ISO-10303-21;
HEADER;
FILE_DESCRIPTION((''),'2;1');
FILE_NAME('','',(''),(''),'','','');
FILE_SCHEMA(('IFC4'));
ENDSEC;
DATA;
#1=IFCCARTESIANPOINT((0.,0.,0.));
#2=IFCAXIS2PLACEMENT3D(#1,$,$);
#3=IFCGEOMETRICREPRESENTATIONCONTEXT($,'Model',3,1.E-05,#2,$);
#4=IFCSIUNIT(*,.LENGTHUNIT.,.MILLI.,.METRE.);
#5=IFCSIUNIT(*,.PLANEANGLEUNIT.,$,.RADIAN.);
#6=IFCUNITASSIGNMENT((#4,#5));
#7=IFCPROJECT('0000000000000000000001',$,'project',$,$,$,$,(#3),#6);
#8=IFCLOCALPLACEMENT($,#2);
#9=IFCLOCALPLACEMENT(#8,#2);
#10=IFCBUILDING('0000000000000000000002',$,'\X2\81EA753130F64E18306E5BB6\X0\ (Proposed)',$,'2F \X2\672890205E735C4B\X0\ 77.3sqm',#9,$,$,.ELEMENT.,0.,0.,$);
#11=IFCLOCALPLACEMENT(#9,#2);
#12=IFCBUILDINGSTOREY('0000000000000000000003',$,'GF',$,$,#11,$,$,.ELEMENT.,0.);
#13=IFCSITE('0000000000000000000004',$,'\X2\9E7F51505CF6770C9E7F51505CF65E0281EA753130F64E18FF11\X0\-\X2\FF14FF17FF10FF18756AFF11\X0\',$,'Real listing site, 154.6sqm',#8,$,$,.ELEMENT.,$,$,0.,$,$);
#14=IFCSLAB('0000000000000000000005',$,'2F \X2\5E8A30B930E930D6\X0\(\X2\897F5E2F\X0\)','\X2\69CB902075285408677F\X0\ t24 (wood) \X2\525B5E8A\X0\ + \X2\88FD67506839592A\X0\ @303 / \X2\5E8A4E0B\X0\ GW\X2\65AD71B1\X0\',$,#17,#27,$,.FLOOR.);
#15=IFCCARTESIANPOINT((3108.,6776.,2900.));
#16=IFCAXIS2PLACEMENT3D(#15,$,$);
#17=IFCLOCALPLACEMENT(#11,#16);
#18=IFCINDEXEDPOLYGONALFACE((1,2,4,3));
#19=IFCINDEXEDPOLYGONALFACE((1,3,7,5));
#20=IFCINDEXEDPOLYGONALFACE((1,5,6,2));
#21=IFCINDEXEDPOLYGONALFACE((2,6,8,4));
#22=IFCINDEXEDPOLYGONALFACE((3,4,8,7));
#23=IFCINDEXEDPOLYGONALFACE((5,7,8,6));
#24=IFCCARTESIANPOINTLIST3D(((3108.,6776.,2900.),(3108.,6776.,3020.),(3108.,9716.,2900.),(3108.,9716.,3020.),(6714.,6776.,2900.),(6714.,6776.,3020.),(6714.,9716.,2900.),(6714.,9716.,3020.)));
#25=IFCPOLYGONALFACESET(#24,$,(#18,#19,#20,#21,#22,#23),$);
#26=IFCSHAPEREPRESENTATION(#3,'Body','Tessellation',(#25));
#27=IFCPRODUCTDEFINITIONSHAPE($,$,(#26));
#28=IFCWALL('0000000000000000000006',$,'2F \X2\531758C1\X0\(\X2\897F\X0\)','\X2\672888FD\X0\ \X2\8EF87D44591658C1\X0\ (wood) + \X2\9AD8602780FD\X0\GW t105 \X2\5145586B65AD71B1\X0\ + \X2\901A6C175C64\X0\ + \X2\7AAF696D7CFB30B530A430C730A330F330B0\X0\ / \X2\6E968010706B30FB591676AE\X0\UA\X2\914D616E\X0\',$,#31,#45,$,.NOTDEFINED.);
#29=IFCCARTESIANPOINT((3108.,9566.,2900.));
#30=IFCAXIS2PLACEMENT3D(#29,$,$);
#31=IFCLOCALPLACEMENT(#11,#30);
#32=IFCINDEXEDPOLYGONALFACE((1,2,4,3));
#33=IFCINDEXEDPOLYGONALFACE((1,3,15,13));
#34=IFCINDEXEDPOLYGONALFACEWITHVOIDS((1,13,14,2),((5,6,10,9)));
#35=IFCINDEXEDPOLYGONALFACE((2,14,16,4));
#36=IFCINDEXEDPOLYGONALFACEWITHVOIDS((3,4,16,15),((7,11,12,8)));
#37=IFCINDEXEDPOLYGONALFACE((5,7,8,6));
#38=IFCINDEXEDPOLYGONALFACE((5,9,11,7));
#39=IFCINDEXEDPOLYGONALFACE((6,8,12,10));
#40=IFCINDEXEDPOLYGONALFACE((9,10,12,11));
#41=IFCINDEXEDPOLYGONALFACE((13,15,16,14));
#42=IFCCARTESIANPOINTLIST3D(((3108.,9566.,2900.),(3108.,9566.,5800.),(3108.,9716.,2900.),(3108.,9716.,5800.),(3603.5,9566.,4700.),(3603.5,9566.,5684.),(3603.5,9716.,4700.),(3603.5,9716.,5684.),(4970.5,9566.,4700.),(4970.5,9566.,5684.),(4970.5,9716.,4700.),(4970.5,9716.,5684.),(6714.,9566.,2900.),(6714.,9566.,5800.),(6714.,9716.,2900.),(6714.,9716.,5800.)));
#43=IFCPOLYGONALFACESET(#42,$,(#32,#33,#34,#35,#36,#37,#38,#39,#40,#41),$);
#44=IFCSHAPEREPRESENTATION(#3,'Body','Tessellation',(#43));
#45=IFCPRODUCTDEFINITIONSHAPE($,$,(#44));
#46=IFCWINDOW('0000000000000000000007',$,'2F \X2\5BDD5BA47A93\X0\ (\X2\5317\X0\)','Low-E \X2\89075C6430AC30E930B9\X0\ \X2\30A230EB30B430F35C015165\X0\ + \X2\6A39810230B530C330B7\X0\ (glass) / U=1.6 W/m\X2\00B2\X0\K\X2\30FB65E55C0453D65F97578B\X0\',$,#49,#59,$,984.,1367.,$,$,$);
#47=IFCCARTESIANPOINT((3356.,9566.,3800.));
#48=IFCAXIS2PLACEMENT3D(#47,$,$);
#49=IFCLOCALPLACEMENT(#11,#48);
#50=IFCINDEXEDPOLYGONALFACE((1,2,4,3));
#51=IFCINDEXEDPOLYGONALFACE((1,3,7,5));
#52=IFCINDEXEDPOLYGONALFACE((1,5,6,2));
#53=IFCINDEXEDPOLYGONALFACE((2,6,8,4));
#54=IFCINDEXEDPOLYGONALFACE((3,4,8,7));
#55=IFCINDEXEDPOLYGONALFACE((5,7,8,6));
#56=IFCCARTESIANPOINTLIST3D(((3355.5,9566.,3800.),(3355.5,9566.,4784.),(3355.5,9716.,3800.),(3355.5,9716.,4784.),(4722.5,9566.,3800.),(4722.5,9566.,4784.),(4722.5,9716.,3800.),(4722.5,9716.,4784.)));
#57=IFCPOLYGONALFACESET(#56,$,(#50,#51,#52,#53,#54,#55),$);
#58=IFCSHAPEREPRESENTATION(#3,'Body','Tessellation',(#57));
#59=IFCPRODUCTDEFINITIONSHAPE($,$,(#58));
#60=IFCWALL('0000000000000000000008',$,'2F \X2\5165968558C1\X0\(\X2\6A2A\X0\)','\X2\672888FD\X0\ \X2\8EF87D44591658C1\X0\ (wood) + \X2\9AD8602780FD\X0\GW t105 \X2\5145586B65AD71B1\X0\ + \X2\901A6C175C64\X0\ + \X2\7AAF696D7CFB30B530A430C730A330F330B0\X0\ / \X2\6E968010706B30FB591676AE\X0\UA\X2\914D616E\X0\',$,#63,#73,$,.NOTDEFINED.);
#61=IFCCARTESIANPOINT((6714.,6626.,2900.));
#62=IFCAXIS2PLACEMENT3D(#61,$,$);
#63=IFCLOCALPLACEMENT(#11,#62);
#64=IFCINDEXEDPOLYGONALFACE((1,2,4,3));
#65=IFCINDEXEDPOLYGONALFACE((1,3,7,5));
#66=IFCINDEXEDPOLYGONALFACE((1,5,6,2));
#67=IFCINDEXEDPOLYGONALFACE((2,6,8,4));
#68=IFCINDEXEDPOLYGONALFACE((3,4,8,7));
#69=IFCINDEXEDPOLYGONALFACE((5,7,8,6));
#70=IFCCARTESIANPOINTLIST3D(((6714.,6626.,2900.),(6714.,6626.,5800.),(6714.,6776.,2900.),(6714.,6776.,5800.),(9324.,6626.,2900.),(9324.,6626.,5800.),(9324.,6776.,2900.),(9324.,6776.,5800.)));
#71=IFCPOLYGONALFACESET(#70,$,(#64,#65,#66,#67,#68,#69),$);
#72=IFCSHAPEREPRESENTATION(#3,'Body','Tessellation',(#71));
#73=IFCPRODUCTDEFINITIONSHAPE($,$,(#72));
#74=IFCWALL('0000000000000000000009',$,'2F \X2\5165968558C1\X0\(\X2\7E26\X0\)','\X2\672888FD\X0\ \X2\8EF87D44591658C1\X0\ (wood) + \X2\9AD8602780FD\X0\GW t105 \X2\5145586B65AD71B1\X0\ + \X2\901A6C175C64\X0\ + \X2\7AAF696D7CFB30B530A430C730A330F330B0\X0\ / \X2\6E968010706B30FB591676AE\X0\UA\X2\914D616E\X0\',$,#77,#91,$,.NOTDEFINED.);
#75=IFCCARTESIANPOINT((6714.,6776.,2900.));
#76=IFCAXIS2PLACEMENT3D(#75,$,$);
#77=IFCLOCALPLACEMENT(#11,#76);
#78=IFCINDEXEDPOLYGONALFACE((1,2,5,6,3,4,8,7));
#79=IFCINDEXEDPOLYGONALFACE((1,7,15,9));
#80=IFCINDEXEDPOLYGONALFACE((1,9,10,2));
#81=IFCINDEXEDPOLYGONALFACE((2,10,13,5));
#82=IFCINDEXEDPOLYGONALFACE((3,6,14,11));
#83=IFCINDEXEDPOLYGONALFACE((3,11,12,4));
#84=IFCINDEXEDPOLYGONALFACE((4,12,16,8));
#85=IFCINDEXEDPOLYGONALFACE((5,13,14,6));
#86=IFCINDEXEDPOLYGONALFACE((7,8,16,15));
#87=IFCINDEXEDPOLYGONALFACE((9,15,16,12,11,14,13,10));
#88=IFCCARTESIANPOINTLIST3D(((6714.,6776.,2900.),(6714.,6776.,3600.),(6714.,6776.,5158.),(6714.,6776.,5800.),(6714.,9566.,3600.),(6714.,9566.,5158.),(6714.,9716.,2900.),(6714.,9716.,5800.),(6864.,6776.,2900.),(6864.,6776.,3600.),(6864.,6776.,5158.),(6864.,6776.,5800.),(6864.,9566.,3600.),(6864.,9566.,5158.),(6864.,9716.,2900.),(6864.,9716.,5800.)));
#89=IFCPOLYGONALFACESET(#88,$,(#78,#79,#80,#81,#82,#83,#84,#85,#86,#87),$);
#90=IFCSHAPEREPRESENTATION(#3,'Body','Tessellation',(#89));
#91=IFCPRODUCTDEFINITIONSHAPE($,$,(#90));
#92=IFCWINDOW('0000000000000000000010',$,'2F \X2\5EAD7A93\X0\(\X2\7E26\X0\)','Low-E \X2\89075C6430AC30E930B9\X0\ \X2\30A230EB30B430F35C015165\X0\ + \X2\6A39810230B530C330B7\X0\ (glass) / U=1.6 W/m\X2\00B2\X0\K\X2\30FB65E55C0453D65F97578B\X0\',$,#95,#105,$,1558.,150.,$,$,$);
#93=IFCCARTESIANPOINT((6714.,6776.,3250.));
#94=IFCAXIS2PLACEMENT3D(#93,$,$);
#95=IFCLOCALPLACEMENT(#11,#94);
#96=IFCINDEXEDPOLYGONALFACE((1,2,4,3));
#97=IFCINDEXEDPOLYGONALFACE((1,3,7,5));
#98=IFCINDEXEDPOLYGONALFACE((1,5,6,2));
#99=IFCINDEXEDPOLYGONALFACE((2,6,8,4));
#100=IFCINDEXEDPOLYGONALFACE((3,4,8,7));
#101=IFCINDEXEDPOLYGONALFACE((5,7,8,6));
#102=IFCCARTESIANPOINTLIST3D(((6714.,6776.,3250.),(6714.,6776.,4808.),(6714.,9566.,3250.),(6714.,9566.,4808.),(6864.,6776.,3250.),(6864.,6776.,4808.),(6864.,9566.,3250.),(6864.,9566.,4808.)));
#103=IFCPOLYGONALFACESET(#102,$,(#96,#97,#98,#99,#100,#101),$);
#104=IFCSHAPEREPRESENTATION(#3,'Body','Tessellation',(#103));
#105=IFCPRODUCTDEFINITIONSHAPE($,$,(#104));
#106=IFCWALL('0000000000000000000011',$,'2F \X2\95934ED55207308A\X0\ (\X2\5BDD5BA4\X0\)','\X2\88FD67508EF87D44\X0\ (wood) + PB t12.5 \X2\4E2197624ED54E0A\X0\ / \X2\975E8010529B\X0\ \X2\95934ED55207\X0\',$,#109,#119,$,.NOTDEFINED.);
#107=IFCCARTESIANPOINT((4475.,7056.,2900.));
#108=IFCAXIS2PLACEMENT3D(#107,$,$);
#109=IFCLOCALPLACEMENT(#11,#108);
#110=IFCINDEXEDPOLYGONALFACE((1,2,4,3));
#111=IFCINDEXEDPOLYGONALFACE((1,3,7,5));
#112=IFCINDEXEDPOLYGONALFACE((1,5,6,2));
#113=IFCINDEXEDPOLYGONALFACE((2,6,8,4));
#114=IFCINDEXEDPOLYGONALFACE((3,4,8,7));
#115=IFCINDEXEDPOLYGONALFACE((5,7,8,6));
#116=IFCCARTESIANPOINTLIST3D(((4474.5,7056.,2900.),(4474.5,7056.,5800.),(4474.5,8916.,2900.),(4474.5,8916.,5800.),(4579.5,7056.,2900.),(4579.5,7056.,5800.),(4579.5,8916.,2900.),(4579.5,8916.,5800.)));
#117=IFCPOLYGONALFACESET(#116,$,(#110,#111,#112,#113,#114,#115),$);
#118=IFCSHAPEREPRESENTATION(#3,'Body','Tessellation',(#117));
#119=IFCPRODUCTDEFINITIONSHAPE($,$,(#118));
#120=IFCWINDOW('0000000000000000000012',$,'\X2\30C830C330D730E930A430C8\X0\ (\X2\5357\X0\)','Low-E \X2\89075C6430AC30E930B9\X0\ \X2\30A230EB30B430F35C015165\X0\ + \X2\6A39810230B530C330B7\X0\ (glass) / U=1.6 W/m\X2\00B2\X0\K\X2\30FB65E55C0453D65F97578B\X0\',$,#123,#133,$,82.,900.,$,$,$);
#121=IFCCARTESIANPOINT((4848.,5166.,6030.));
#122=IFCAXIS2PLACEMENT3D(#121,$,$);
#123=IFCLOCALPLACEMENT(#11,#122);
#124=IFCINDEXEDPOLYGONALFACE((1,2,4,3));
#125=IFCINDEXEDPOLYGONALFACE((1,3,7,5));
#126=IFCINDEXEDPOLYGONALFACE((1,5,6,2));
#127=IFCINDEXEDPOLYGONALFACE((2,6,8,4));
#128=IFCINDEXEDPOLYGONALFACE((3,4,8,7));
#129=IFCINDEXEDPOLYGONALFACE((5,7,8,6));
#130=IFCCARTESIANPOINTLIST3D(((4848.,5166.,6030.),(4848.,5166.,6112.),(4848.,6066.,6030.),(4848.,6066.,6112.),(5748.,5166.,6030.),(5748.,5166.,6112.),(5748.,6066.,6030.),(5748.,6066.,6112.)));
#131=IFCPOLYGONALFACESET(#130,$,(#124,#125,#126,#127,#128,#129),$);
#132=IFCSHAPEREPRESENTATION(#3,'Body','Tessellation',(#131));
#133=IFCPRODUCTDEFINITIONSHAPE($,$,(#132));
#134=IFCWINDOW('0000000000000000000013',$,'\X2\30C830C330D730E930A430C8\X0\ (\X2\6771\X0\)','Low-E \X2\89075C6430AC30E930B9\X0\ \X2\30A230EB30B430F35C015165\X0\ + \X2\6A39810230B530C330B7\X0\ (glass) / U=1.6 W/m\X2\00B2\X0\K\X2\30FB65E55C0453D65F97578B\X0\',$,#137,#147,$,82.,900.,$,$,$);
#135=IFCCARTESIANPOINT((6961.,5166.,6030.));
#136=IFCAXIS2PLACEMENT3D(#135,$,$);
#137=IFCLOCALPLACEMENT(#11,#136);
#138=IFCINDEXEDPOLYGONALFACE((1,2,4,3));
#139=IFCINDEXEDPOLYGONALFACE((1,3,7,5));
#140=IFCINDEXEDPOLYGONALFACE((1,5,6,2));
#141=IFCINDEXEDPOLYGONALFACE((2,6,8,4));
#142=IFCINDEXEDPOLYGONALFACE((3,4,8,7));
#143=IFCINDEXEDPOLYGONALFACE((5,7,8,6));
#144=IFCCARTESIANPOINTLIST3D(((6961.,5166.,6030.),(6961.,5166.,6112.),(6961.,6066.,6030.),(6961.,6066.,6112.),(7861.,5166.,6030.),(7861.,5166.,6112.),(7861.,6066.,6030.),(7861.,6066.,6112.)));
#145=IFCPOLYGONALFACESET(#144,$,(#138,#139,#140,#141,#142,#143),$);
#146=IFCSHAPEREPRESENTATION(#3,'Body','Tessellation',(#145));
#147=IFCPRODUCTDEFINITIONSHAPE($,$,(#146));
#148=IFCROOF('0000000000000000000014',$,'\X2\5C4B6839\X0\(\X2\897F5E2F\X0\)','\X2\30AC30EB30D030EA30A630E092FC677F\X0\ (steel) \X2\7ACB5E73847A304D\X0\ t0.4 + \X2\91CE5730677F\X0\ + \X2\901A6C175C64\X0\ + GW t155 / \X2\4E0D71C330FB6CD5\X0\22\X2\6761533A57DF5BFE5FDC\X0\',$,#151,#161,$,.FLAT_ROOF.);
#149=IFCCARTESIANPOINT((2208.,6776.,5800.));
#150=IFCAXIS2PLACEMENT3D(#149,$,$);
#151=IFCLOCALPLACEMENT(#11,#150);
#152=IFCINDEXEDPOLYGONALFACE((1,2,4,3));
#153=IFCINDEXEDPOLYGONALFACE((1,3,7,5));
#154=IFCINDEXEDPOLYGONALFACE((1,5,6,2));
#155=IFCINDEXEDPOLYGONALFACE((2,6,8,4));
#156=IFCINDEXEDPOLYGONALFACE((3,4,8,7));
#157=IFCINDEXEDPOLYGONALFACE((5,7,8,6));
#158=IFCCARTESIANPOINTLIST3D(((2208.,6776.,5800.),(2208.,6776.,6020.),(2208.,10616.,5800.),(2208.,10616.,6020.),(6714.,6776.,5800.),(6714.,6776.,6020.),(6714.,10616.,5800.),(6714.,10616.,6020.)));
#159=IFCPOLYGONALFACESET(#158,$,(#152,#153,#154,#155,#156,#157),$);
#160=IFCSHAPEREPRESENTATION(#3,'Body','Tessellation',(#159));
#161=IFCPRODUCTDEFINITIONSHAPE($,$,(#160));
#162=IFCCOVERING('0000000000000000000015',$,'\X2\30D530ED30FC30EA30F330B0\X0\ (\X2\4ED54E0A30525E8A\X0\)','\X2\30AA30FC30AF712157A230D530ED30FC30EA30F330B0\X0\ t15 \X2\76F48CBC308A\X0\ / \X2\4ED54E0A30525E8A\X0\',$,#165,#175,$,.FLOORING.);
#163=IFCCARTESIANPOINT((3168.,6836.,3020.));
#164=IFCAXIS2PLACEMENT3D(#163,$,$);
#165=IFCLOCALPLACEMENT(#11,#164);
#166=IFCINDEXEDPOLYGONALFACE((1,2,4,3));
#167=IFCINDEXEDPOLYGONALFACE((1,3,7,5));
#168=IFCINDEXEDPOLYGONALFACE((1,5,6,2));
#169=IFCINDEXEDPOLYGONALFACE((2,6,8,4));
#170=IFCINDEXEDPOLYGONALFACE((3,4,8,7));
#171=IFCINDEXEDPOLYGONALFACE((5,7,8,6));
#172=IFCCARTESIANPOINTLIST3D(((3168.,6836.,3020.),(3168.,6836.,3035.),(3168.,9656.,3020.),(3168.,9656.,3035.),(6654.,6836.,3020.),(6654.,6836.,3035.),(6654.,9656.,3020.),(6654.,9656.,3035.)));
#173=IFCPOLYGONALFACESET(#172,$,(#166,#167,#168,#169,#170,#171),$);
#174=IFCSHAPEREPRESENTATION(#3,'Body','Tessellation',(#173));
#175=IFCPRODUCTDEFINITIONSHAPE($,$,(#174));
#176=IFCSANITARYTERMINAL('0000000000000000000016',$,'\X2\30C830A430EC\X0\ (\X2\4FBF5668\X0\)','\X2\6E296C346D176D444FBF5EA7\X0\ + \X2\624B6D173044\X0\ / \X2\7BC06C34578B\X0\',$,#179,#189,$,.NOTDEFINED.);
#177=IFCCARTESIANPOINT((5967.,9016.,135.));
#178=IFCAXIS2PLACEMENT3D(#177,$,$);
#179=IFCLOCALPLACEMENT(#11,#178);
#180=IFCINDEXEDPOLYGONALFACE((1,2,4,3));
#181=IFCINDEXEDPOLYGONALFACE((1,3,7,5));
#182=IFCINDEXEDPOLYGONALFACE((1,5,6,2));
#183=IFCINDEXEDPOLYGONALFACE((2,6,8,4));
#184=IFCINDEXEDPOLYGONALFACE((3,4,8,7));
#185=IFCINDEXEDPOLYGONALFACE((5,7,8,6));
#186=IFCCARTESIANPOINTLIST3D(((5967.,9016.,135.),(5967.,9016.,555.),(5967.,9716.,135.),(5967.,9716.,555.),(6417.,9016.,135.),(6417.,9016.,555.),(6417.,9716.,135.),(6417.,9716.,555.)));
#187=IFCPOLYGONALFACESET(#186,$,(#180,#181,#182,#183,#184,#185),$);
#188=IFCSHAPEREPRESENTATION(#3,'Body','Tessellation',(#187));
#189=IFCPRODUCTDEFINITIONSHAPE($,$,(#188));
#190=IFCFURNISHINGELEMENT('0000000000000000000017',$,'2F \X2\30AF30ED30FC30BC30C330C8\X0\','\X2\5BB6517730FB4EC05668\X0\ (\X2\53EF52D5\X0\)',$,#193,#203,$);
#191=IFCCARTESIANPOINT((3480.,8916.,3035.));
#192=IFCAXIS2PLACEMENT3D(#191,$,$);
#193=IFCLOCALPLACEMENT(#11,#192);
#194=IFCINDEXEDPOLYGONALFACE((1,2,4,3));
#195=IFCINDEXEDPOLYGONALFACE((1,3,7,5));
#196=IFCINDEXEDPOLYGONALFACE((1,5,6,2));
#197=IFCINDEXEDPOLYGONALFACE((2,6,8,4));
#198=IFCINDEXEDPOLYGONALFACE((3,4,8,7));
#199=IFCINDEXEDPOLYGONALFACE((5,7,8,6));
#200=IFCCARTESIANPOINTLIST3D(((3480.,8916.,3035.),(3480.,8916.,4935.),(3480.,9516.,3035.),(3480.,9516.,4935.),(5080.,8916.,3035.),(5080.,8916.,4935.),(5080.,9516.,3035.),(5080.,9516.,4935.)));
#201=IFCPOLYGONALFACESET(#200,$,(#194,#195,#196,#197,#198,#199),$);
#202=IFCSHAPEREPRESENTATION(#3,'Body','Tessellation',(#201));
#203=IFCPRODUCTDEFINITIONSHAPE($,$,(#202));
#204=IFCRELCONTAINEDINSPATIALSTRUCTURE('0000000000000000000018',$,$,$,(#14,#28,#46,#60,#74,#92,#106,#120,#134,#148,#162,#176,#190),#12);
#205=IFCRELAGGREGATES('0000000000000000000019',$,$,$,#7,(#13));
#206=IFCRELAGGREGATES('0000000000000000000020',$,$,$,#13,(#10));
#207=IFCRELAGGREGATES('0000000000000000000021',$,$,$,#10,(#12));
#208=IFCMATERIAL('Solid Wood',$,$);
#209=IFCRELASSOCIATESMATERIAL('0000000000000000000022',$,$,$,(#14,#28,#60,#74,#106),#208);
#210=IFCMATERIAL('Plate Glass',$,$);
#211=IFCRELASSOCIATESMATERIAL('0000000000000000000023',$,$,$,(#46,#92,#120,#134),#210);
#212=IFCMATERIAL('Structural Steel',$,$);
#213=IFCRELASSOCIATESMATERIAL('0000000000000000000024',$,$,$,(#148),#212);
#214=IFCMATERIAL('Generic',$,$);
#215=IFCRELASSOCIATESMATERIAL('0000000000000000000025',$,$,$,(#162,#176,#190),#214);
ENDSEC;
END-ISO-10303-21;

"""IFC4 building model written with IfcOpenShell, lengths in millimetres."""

from ifc_helpers import new_model, si_unit, frame, frame_2d, origin, place, context, project, spatial, rectangle, extrude, material, element, fill, save


model = new_model("IFC4")

# Units and contexts
model_context = context("Model", 3, precision=1e-05, world=origin())
ifc_project = project(units=[si_unit("LENGTHUNIT", "METRE", prefix="MILLI"), si_unit("PLANEANGLEUNIT", "RADIAN")], contexts=[model_context])

# Site, building, storey
site_placement = place(None, origin())
site = spatial("IfcSite", under=ifc_project, at=site_placement, Name="鹿児島県鹿児島市自由ヶ丘１-４７０８番１", ObjectType="Real listing site, 154.6sqm", CompositionType="ELEMENT", RefElevation=0.0)
building_placement = place(site_placement, origin())
building = spatial("IfcBuilding", under=site, at=building_placement, Name="自由ヶ丘の家 (Proposed)", ObjectType="2F 木造平屋 77.3sqm", CompositionType="ELEMENT", ElevationOfRefHeight=0.0, ElevationOfTerrain=0.0)
storey_placement = place(building_placement, origin())
storey = spatial("IfcBuildingStorey", under=building, at=storey_placement, Name="GF", CompositionType="ELEMENT", Elevation=0.0)

# Slab
ifc_material_1 = material(Name="Solid Wood")
slab_placement = place(storey_placement, frame((3108.0, 6776.0, 2900.0)))
element("IfcSlab", 1, at=slab_placement, inside=storey, material=ifc_material_1, Name="2F 床スラブ(西帯)", Description="構造用合板 t24 (wood) 剛床 + 製材根太 @303 / 床下 GW断熱", PredefinedType="FLOOR", context=model_context, shape_type="SweptSolid", body=[
    extrude(rectangle(XDim=3606.0, YDim=2940.0, at=frame_2d((1803.0, 1470.0))), frame((3108.0, 6776.0, 2900.0)), (0.0, 0.0, 1.0), 120.0),
])

# Wall, opening, window
wall_1_placement = place(storey_placement, frame((3108.0, 9566.0, 2900.0)))
wall_1 = element("IfcWall", 2, at=wall_1_placement, inside=storey, material=ifc_material_1, Name="2F 北壁(西)", Description="木製 軸組外壁 (wood) + 高性能GW t105 充填断熱 + 通気層 + 窯業系サイディング / 準耐火・外皮UA配慮", PredefinedType="NOTDEFINED", context=model_context, shape_type="SweptSolid", body=[
    extrude(rectangle(XDim=3606.0, YDim=150.0, at=frame_2d((1803.0, 75.0))), frame((3108.0, 9566.0, 2900.0)), (0.0, 0.0, 1.0), 2900.0),
])
opening_1_placement = place(storey_placement, frame((3356.0, 9566.0, 3800.0)))
opening_1 = element("IfcOpeningElement", 3, at=opening_1_placement, cuts=wall_1, PredefinedType="NOTDEFINED", context=model_context, shape_type="SweptSolid", body=[
    extrude(rectangle(XDim=1367.0, YDim=150.0, at=frame_2d((683.0, 75.0))), frame((3356.0, 9566.0, 3800.0)), (0.0, 0.0, 1.0), 984.0),
])
ifc_material_2 = material(Name="Plate Glass")
window_1_placement = place(storey_placement, frame((3356.0, 9566.0, 3800.0)))
window_1 = element("IfcWindow", 4, at=window_1_placement, inside=storey, material=ifc_material_2, Name="2F 寝室窓 (北)", Description="Low-E 複層ガラス アルゴン封入 + 樹脂サッシ (glass) / U=1.6 W/m²K・日射取得型", OverallHeight=984.0, OverallWidth=1367.0, context=model_context, shape_type="SweptSolid", body=[
    extrude(rectangle(XDim=1367.0, YDim=150.0, at=frame_2d((683.0, 75.0))), frame((3356.0, 9566.0, 3800.0)), (0.0, 0.0, 1.0), 984.0),
])
fill(opening_1, window_1)

# Wall
wall_2_placement = place(storey_placement, frame((6714.0, 6626.0, 2900.0)))
element("IfcWall", 5, at=wall_2_placement, inside=storey, material=ifc_material_1, Name="2F 入隅壁(横)", Description="木製 軸組外壁 (wood) + 高性能GW t105 充填断熱 + 通気層 + 窯業系サイディング / 準耐火・外皮UA配慮", PredefinedType="NOTDEFINED", context=model_context, shape_type="SweptSolid", body=[
    extrude(rectangle(XDim=2610.0, YDim=150.0, at=frame_2d((1305.0, 75.0))), frame((6714.0, 6626.0, 2900.0)), (0.0, 0.0, 1.0), 2900.0),
])

# Wall, opening, window
wall_3_placement = place(storey_placement, frame((6714.0, 6776.0, 2900.0)))
wall_3 = element("IfcWall", 6, at=wall_3_placement, inside=storey, material=ifc_material_1, Name="2F 入隅壁(縦)", Description="木製 軸組外壁 (wood) + 高性能GW t105 充填断熱 + 通気層 + 窯業系サイディング / 準耐火・外皮UA配慮", PredefinedType="NOTDEFINED", context=model_context, shape_type="SweptSolid", body=[
    extrude(rectangle(XDim=150.0, YDim=2940.0, at=frame_2d((75.0, 1470.0))), frame((6714.0, 6776.0, 2900.0)), (0.0, 0.0, 1.0), 2900.0),
])
opening_2_placement = place(storey_placement, frame((6714.0, 6776.0, 3250.0)))
opening_2 = element("IfcOpeningElement", 7, at=opening_2_placement, cuts=wall_3, PredefinedType="NOTDEFINED", context=model_context, shape_type="SweptSolid", body=[
    extrude(rectangle(XDim=150.0, YDim=2790.0, at=frame_2d((75.0, 1395.0))), frame((6714.0, 6776.0, 3250.0)), (0.0, 0.0, 1.0), 1558.0),
])
window_2_placement = place(storey_placement, frame((6714.0, 6776.0, 3250.0)))
window_2 = element("IfcWindow", 8, at=window_2_placement, inside=storey, material=ifc_material_2, Name="2F 庭窓(縦)", Description="Low-E 複層ガラス アルゴン封入 + 樹脂サッシ (glass) / U=1.6 W/m²K・日射取得型", OverallHeight=1558.0, OverallWidth=150.0, context=model_context, shape_type="SweptSolid", body=[
    extrude(rectangle(XDim=150.0, YDim=2790.0, at=frame_2d((75.0, 1395.0))), frame((6714.0, 6776.0, 3250.0)), (0.0, 0.0, 1.0), 1558.0),
])
fill(opening_2, window_2)

# Wall
wall_4_placement = place(storey_placement, frame((4475.0, 7056.0, 2900.0)))
element("IfcWall", 9, at=wall_4_placement, inside=storey, material=ifc_material_1, Name="2F 間仕切り (寝室)", Description="製材軸組 (wood) + PB t12.5 両面仕上 / 非耐力 間仕切", PredefinedType="NOTDEFINED", context=model_context, shape_type="SweptSolid", body=[
    extrude(rectangle(XDim=105.0, YDim=1860.0, at=frame_2d((52.0, 930.0))), frame((4475.0, 7056.0, 2900.0)), (0.0, 0.0, 1.0), 2900.0),
])

# Windows
window_3_placement = place(storey_placement, frame((4848.0, 5166.0, 6030.0)))
element("IfcWindow", 10, at=window_3_placement, inside=storey, material=ifc_material_2, Name="トップライト (南)", Description="Low-E 複層ガラス アルゴン封入 + 樹脂サッシ (glass) / U=1.6 W/m²K・日射取得型", OverallHeight=82.0, OverallWidth=900.0, context=model_context, shape_type="SweptSolid", body=[
    extrude(rectangle(XDim=900.0, YDim=900.0, at=frame_2d((450.0, 450.0))), frame((4848.0, 5166.0, 6030.0)), (0.0, 0.0, 1.0), 82.0),
])
window_4_placement = place(storey_placement, frame((6961.0, 5166.0, 6030.0)))
element("IfcWindow", 11, at=window_4_placement, inside=storey, material=ifc_material_2, Name="トップライト (東)", Description="Low-E 複層ガラス アルゴン封入 + 樹脂サッシ (glass) / U=1.6 W/m²K・日射取得型", OverallHeight=82.0, OverallWidth=900.0, context=model_context, shape_type="SweptSolid", body=[
    extrude(rectangle(XDim=900.0, YDim=900.0, at=frame_2d((450.0, 450.0))), frame((6961.0, 5166.0, 6030.0)), (0.0, 0.0, 1.0), 82.0),
])

# Roof
ifc_material_3 = material(Name="Structural Steel")
for number, where, name in (
    (12, (2208.0, 6776.0, 5800.0), "屋根(西帯)"),
):
    element("IfcRoof", number, at=place(storey_placement, frame(where)), inside=storey, material=ifc_material_3, Name=name, Description="ガルバリウム鋼板 (steel) 立平葺き t0.4 + 野地板 + 通気層 + GW t155 / 不燃・法22条区域対応", PredefinedType="FLAT_ROOF", context=model_context, shape_type="SweptSolid", body=[
        extrude(rectangle(XDim=4506.0, YDim=3840.0, at=frame_2d((2253.0, 1920.0))), frame((2208.0, 6776.0, 5800.0)), (0.0, 0.0, 1.0), 220.0),
    ])

# Covering
ifc_material_4 = material(Name="Generic")
covering_placement = place(storey_placement, frame((3168.0, 6836.0, 3020.0)))
element("IfcCovering", 13, at=covering_placement, inside=storey, material=ifc_material_4, Name="フローリング (仕上げ床)", Description="オーク無垢フローリング t15 直貼り / 仕上げ床", PredefinedType="FLOORING", context=model_context, shape_type="SweptSolid", body=[
    extrude(rectangle(XDim=3486.0, YDim=2820.0, at=frame_2d((1743.0, 1410.0))), frame((3168.0, 6836.0, 3020.0)), (0.0, 0.0, 1.0), 15.0),
])

# Sanitary terminal
sanitary_terminal_placement = place(storey_placement, frame((5967.0, 9016.0, 135.0)))
element("IfcSanitaryTerminal", 14, at=sanitary_terminal_placement, inside=storey, material=ifc_material_4, Name="トイレ (便器)", Description="温水洗浄便座 + 手洗い / 節水型", PredefinedType="NOTDEFINED", context=model_context, shape_type="SweptSolid", body=[
    extrude(rectangle(XDim=450.0, YDim=700.0, at=frame_2d((225.0, 350.0))), frame((5967.0, 9016.0, 135.0)), (0.0, 0.0, 1.0), 420.0),
])

# Furnishing element
furnishing_1_placement = place(storey_placement, frame((3480.0, 8916.0, 3035.0)))
element("IfcFurnishingElement", 15, at=furnishing_1_placement, inside=storey, material=ifc_material_4, Name="2F クローゼット", Description="家具・什器 (可動)", context=model_context, shape_type="SweptSolid", body=[
    extrude(rectangle(XDim=1600.0, YDim=600.0, at=frame_2d((800.0, 300.0))), frame((3480.0, 8916.0, 3035.0)), (0.0, 0.0, 1.0), 1900.0),
])

save(model, "model.ifc")
